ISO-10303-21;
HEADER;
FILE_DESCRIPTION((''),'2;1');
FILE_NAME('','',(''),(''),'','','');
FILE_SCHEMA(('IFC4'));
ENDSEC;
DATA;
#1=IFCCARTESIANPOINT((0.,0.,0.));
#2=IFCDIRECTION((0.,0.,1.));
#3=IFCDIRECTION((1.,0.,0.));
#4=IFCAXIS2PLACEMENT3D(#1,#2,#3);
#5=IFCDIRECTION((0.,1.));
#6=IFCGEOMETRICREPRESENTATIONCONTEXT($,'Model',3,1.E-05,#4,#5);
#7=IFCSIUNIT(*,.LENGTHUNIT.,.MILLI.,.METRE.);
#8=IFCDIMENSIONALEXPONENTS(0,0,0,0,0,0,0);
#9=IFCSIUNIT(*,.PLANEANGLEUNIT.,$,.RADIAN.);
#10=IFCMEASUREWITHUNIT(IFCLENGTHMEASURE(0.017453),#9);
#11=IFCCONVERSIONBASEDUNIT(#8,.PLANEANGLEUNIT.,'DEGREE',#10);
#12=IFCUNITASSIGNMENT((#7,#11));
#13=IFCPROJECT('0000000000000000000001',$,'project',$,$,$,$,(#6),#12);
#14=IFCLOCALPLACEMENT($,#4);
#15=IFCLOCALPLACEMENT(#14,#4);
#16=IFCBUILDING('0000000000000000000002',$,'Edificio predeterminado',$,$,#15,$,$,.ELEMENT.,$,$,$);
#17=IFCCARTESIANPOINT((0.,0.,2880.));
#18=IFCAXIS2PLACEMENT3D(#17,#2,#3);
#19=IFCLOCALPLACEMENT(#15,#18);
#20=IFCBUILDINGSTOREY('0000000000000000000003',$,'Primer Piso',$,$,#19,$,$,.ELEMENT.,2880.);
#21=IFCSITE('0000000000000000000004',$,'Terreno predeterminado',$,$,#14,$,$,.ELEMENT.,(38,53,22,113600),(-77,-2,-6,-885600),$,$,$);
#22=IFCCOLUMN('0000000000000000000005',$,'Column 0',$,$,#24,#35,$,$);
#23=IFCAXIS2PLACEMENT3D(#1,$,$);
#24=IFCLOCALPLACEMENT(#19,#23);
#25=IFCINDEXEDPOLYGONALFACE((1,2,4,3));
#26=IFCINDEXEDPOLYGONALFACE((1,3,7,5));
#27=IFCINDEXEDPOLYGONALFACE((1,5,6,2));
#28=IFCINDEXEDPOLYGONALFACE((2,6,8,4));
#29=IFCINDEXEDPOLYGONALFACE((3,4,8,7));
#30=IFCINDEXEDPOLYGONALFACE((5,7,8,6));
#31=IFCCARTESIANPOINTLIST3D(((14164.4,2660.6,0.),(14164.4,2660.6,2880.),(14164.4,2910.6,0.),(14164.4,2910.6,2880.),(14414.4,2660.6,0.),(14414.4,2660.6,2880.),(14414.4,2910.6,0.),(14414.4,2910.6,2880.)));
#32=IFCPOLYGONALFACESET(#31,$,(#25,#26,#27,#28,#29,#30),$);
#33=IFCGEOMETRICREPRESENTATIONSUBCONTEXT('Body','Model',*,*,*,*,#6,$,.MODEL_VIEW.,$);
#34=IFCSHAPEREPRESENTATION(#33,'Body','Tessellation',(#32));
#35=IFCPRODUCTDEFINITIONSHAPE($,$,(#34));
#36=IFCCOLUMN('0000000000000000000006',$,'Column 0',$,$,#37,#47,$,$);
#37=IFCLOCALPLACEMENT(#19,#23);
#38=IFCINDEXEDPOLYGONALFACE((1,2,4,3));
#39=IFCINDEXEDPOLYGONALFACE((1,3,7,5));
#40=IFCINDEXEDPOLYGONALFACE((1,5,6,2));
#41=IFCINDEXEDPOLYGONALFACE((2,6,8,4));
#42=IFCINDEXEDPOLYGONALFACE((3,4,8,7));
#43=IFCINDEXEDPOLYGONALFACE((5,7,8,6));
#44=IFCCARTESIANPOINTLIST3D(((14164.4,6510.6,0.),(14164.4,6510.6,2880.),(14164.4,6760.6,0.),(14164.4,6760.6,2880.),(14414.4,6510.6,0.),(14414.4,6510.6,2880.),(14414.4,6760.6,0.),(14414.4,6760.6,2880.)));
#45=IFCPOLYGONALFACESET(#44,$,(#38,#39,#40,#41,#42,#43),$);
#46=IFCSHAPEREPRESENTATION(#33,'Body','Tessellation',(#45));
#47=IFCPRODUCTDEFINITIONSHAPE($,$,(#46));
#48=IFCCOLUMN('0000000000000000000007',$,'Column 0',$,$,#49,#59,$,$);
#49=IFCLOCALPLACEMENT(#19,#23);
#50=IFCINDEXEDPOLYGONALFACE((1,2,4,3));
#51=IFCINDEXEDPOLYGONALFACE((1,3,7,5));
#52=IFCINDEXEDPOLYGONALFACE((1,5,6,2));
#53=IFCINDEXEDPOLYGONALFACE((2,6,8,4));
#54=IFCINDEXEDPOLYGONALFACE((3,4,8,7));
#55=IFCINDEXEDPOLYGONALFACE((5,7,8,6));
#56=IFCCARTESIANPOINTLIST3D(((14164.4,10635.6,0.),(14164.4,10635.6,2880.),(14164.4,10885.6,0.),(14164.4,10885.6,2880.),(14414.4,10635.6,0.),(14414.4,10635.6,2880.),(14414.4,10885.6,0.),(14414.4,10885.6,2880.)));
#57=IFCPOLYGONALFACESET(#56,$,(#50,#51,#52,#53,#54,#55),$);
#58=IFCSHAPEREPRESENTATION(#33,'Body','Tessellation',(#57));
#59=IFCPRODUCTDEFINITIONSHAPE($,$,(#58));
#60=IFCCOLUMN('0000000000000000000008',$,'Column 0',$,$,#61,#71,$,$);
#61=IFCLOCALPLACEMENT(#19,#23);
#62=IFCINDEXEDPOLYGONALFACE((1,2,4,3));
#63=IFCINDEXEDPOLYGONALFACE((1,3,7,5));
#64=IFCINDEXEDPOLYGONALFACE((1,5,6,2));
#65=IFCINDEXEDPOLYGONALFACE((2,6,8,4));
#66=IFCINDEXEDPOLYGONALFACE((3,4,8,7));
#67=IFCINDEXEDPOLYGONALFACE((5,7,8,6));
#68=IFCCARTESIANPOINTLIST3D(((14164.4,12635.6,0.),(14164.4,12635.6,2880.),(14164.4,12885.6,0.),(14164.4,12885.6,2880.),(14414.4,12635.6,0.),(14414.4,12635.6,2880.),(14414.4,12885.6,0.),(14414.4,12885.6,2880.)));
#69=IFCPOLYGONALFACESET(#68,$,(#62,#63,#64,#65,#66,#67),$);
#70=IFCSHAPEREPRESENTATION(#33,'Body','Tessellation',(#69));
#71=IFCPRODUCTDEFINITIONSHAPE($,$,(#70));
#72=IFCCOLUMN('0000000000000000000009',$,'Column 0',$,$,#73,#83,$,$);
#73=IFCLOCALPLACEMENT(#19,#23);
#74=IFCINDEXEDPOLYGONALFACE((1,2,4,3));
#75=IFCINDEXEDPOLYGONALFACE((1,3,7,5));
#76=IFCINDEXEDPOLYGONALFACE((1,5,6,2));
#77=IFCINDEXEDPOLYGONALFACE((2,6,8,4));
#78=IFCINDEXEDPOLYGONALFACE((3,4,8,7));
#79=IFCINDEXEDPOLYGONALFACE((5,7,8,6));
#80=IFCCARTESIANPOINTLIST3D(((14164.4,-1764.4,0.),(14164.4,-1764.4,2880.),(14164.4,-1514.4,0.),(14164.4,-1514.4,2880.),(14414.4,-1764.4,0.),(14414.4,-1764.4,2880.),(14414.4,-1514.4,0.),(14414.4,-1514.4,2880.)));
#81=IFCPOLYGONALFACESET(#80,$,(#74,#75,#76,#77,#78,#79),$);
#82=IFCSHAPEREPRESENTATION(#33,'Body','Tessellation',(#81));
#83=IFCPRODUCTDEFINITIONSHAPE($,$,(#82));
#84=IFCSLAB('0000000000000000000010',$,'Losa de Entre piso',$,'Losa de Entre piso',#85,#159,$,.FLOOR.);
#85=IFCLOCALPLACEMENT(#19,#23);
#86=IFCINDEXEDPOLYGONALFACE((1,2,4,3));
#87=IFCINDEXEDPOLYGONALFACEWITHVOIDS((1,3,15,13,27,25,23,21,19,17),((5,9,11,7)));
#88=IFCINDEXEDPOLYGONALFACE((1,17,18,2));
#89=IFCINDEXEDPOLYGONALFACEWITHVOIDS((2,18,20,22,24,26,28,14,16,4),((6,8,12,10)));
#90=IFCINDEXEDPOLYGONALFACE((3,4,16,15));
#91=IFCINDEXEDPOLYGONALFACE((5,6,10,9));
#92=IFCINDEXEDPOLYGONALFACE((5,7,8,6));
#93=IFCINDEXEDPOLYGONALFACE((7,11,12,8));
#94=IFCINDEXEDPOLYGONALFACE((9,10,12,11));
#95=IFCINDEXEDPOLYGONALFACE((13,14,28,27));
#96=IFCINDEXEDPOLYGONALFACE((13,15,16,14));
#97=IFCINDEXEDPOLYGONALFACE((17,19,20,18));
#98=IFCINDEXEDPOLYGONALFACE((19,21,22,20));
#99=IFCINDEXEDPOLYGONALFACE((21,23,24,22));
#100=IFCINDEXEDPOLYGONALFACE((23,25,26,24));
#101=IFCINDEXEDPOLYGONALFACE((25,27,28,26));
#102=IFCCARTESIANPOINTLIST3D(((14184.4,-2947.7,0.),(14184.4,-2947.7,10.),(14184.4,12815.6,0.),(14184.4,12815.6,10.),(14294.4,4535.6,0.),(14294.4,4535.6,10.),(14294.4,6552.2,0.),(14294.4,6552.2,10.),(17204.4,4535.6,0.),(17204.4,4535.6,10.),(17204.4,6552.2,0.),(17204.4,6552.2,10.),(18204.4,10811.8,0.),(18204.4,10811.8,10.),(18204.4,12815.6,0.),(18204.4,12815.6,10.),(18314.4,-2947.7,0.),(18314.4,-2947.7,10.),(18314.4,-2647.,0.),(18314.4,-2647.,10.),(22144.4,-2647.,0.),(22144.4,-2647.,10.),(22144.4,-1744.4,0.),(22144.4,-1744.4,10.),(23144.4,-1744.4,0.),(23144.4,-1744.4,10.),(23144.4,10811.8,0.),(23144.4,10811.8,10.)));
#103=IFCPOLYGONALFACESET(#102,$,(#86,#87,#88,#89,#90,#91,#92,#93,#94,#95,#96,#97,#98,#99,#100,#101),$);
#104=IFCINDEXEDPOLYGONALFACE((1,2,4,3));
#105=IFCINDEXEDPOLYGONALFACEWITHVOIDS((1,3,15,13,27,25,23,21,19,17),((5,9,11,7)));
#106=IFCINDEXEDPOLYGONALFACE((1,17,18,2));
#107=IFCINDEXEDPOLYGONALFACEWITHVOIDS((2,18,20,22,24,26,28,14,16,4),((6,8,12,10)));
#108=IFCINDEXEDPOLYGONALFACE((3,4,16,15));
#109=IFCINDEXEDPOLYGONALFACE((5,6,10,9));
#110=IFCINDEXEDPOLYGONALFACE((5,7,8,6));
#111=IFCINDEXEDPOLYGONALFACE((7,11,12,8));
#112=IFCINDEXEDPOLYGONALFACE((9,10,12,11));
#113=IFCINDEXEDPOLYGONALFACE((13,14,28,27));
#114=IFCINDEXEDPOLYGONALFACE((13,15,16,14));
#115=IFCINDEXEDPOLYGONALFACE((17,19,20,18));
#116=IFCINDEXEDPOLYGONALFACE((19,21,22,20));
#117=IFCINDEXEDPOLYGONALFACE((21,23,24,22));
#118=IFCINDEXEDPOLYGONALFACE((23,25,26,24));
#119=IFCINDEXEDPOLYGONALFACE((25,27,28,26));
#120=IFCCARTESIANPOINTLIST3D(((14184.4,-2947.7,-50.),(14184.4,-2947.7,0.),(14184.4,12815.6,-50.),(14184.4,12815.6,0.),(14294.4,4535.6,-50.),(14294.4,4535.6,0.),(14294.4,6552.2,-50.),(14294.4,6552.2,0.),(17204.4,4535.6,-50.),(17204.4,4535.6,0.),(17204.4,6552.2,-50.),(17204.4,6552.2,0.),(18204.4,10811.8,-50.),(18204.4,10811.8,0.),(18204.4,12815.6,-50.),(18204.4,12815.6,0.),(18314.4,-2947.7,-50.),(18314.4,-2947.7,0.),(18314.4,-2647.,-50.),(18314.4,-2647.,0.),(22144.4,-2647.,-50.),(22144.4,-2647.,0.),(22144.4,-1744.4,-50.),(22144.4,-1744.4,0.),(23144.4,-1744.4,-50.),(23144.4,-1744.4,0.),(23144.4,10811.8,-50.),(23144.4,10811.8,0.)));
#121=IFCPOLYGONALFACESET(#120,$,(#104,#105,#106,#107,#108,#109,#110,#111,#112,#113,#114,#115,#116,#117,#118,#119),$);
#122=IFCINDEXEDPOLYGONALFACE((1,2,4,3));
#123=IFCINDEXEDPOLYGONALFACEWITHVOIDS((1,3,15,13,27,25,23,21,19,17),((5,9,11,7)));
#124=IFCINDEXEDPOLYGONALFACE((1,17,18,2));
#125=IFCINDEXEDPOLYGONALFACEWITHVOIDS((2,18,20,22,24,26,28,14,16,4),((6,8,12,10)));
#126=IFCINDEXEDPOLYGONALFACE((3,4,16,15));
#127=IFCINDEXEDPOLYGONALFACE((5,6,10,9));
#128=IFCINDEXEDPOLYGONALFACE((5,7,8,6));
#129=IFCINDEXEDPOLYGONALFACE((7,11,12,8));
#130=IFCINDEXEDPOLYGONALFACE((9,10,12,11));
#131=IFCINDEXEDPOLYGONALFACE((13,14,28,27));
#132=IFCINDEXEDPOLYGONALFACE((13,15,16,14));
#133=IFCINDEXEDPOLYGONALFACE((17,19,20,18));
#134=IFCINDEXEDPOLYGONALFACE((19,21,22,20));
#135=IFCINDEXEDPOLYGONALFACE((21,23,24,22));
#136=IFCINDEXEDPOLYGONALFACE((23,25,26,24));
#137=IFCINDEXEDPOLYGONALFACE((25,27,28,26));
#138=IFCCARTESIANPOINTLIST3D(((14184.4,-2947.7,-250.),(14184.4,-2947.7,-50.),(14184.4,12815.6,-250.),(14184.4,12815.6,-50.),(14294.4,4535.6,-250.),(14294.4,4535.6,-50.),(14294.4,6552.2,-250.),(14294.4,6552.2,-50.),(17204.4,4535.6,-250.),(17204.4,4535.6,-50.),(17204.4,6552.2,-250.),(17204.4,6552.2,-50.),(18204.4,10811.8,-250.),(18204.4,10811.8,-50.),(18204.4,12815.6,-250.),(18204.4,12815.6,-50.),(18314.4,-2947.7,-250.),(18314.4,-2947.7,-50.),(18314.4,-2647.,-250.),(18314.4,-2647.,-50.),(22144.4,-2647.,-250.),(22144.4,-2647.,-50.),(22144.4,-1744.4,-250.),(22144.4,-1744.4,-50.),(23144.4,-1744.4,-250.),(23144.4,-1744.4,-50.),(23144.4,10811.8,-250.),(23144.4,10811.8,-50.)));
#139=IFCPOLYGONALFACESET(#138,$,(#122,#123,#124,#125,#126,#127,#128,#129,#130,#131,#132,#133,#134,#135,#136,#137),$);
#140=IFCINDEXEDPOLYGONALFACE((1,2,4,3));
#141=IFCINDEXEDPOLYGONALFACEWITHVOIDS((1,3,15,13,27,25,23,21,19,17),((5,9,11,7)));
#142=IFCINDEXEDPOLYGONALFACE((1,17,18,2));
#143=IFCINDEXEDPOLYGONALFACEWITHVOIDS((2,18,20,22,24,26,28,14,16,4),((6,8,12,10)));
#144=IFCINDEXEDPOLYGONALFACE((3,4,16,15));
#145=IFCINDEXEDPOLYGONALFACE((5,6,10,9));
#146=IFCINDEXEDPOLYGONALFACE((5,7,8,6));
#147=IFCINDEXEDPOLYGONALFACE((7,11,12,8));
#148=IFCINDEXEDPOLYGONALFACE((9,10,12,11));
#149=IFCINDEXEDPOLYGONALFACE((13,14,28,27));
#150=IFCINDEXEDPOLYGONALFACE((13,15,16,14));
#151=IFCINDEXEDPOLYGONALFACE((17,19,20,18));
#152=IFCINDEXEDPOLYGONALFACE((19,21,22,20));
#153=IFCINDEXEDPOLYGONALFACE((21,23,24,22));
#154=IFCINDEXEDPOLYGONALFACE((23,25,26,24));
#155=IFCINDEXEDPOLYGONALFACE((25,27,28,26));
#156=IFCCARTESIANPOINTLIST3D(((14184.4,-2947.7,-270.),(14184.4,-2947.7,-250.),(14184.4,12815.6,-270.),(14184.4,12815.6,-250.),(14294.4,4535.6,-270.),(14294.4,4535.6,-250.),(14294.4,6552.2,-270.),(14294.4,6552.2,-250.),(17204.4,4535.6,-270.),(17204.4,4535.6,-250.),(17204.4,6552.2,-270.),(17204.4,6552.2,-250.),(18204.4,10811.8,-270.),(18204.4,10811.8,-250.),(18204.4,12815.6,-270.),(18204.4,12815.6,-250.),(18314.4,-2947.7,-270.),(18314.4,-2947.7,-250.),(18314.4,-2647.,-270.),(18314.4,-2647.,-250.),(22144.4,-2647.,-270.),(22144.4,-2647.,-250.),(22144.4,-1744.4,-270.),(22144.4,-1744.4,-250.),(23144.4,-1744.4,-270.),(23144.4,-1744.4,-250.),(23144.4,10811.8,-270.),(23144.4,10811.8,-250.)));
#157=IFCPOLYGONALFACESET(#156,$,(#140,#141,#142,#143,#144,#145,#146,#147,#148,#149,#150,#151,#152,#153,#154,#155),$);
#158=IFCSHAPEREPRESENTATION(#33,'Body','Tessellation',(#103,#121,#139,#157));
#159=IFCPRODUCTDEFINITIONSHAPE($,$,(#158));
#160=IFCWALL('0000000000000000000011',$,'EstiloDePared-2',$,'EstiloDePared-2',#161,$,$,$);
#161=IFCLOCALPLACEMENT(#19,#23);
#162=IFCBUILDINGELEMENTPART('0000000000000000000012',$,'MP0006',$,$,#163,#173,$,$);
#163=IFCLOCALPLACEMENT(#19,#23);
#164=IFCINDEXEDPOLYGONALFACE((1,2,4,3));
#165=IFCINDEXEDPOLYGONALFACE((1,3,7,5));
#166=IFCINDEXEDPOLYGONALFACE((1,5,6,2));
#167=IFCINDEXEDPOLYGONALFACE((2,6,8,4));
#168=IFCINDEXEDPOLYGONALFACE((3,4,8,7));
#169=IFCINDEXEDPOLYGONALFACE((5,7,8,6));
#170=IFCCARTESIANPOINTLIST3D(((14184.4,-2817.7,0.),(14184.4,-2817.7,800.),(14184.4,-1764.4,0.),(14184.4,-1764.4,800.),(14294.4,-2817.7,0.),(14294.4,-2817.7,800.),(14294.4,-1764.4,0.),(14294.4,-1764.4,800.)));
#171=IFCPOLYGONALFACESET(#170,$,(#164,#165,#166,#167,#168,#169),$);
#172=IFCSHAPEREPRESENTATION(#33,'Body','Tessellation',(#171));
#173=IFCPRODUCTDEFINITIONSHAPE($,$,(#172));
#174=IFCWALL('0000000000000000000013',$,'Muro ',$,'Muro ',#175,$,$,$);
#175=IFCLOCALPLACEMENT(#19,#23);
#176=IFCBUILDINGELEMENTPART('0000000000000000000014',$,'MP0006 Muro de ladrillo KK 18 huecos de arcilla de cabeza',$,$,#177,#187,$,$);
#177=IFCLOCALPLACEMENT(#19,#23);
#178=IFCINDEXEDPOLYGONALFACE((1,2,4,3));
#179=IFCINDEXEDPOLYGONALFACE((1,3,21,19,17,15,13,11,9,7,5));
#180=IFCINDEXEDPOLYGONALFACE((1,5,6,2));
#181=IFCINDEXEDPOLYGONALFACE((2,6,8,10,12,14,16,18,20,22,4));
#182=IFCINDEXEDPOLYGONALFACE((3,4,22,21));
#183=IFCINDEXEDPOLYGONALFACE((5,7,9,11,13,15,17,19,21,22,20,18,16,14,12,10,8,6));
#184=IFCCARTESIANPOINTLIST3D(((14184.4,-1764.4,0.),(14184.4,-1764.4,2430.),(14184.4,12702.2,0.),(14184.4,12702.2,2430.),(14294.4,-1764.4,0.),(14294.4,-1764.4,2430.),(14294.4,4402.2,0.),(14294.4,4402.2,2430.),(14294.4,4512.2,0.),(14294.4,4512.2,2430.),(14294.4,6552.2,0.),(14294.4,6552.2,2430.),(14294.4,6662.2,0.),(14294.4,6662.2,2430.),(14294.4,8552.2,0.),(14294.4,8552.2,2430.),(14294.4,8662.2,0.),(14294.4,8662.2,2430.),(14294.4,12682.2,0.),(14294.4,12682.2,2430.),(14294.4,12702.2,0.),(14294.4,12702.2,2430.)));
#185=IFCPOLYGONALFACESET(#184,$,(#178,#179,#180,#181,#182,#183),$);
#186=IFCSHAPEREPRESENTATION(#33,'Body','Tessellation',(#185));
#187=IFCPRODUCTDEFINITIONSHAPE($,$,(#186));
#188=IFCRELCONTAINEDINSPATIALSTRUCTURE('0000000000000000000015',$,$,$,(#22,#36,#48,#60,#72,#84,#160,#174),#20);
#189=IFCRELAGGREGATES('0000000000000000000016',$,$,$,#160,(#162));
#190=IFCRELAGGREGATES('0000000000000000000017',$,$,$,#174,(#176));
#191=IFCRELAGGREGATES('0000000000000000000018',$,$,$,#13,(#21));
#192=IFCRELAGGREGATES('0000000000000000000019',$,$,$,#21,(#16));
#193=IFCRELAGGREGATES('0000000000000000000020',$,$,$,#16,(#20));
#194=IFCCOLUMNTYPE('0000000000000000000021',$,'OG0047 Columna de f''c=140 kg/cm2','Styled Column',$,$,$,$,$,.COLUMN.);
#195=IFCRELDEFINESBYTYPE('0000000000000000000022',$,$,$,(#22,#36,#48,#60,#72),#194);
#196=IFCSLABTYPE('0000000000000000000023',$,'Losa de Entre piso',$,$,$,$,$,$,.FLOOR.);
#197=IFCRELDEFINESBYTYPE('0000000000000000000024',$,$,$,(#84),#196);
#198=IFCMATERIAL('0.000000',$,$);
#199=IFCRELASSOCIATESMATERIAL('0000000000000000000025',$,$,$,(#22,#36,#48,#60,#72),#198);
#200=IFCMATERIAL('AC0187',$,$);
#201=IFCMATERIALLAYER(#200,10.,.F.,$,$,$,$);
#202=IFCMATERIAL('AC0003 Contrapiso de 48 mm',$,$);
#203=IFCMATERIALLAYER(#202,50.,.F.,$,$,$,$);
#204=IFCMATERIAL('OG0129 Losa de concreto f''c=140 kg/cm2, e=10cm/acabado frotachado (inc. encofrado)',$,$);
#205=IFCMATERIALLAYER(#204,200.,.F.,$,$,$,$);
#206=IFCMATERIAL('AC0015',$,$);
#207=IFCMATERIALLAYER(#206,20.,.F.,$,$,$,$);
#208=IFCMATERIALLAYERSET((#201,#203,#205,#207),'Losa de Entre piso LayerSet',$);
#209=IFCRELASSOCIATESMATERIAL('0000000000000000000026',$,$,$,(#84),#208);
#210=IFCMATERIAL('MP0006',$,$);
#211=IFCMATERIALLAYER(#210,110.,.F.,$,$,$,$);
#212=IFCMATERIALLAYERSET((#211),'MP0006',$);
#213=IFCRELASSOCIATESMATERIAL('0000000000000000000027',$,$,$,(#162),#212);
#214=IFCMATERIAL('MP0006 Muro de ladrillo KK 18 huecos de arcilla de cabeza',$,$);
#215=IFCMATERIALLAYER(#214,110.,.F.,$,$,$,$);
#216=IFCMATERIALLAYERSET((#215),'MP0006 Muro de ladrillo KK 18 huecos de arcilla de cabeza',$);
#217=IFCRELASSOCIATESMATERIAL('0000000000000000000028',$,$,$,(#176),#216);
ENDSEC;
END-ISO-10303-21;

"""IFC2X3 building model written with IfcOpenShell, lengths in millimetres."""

from ifc_helpers import new_model, entity, si_unit, converted_unit, direction, frame, origin_with_axes, place, context, subcontext, project, spatial, polyline, outline, extrude, material, layer, layer_set, layer_usage, type_object, element, aggregate, save


model = new_model("IFC2X3")

# Units and contexts
model_context = context("Model", 3, precision=1e-05, world=origin_with_axes(), true_north=direction((0.0, 1.0)))
body_context = subcontext(model_context, "Body", "Model", "MODEL_VIEW")
ifc_project = project(units=[si_unit("LENGTHUNIT", "METRE", prefix="MILLI"), converted_unit("PLANEANGLEUNIT", "DEGREE", entity("IfcLengthMeasure", 0.017453), si_unit("PLANEANGLEUNIT", "RADIAN"), dimensions=[0, 0, 0, 0, 0, 0, 0])], contexts=[model_context])

# Site, building, storey
site_placement = place(None, origin_with_axes())
site = spatial("IfcSite", under=ifc_project, at=site_placement, Name="Terreno predeterminado", CompositionType="ELEMENT", RefLatitude=(38, 53, 22, 113600), RefLongitude=(-77, -2, -6, -885600))
building_placement = place(site_placement, origin_with_axes())
building = spatial("IfcBuilding", under=site, at=building_placement, Name="Edificio predeterminado", CompositionType="ELEMENT")
storey_placement = place(building_placement, frame((0.0, 0.0, 2880.0), z_axis=(0.0, 0.0, 1.0), x_axis=(1.0, 0.0, 0.0)))
storey = spatial("IfcBuildingStorey", under=building, at=storey_placement, Name="Primer Piso", CompositionType="ELEMENT", Elevation=2880.0)

# Columns
ifc_material_1 = material(Name="0.000000")
column_type = type_object("IfcColumnType", Name="OG0047 Columna de f'c=140 kg/cm2", Description="Styled Column", PredefinedType="COLUMN")
for number, where, z_axis, x_axis, name in (
    (1, (14289.4, 2785.6, 0.0), (0.0, 0.0, 1.0), (1.0, 0.0, 0.0), "Column 0"),
    (2, (14289.4, 6635.6, 0.0), (0.0, 0.0, 1.0), (1.0, 0.0, 0.0), "Column 0"),
    (3, (14289.4, 10760.6, 0.0), (0.0, 0.0, 1.0), (1.0, 0.0, 0.0), "Column 0"),
    (4, (14289.4, 12760.6, 0.0), (0.0, 0.0, 1.0), (1.0, 0.0, 0.0), "Column 0"),
    (5, (14289.4, -1639.4, 0.0), (0.0, 0.0, 1.0), (1.0, 0.0, 0.0), "Column 0"),
):
    element("IfcColumn", number, at=place(storey_placement, frame(where, z_axis=z_axis, x_axis=x_axis)), inside=storey, type_object=column_type, material=ifc_material_1, Name=name, context=body_context, shape_type="SweptSolid", body=[
        extrude(outline(polyline([(-125.0, -125.0), (125.0, -125.0), (125.0, 125.0), (-125.0, 125.0), (-125.0, -125.0)])), origin_with_axes(), (0.0, 0.0, 1.0), 2880.0),
    ])

# Slab
ifc_material_2 = material(Name="AC0187")
ifc_layer_1 = layer(ifc_material_2, 10.0, ventilated=False)
ifc_material_3 = material(Name="AC0003 Contrapiso de 48 mm")
ifc_layer_2 = layer(ifc_material_3, 50.0, ventilated=False)
ifc_material_4 = material(Name="OG0129 Losa de concreto f'c=140 kg/cm2, e=10cm/acabado frotachado (inc. encofrado)")
ifc_layer_3 = layer(ifc_material_4, 200.0, ventilated=False)
ifc_material_5 = material(Name="AC0015")
ifc_layer_4 = layer(ifc_material_5, 20.0, ventilated=False)
ifc_layer_set_1 = layer_set([ifc_layer_1, ifc_layer_2, ifc_layer_3, ifc_layer_4], Name="Losa de Entre piso LayerSet")
ifc_layer_usage_1 = layer_usage(ifc_layer_set_1, "AXIS3", "NEGATIVE", 0.0)
slab_type = type_object("IfcSlabType", Name="Losa de Entre piso", PredefinedType="FLOOR")
slab_placement = place(storey_placement, frame((0.0, 0.0, -2880.0), z_axis=(0.0, 0.0, 1.0), x_axis=(1.0, 0.0, 0.0)))
element("IfcSlab", 6, at=slab_placement, inside=storey, type_object=slab_type, material=ifc_layer_usage_1, Name="Losa de Entre piso", ObjectType="Losa de Entre piso", PredefinedType="FLOOR", context=body_context, shape_type="SweptSolid", body=[
    extrude(outline(polyline([(0.0, 15763.4), (4130.0, 15763.4), (4130.0, 15462.6), (7960.0, 15462.6), (7960.0, 14560.0), (8960.0, 14560.0), (8960.0, 2003.8), (4020.0, 2003.8), (4020.0, 0.0), (0.0, 0.0), (0.0, 15763.4)]), holes=[polyline([(110.0, 6263.4), (3020.0, 6263.4), (3020.0, 8280.0), (110.0, 8280.0), (110.0, 6263.4)])]), frame((14184.4, 12815.6, 2880.0), z_axis=(0.0, 0.0, -1.0), x_axis=(1.0, 0.0, 0.0)), (0.0, 0.0, -1.0), 10.0),
    extrude(outline(polyline([(0.0, 15763.4), (4130.0, 15763.4), (4130.0, 15462.6), (7960.0, 15462.6), (7960.0, 14560.0), (8960.0, 14560.0), (8960.0, 2003.8), (4020.0, 2003.8), (4020.0, 0.0), (0.0, 0.0), (0.0, 15763.4)]), holes=[polyline([(110.0, 6263.4), (3020.0, 6263.4), (3020.0, 8280.0), (110.0, 8280.0), (110.0, 6263.4)])]), frame((14184.4, 12815.6, 2830.0), z_axis=(0.0, 0.0, -1.0), x_axis=(1.0, 0.0, 0.0)), (0.0, 0.0, -1.0), 50.0),
    extrude(outline(polyline([(0.0, 15763.4), (4130.0, 15763.4), (4130.0, 15462.6), (7960.0, 15462.6), (7960.0, 14560.0), (8960.0, 14560.0), (8960.0, 2003.8), (4020.0, 2003.8), (4020.0, 0.0), (0.0, 0.0), (0.0, 15763.4)]), holes=[polyline([(110.0, 6263.4), (3020.0, 6263.4), (3020.0, 8280.0), (110.0, 8280.0), (110.0, 6263.4)])]), frame((14184.4, 12815.6, 2630.0), z_axis=(0.0, 0.0, -1.0), x_axis=(1.0, 0.0, 0.0)), (0.0, 0.0, -1.0), 200.0),
    extrude(outline(polyline([(0.0, 15763.4), (4130.0, 15763.4), (4130.0, 15462.6), (7960.0, 15462.6), (7960.0, 14560.0), (8960.0, 14560.0), (8960.0, 2003.8), (4020.0, 2003.8), (4020.0, 0.0), (0.0, 0.0), (0.0, 15763.4)]), holes=[polyline([(110.0, 6263.4), (3020.0, 6263.4), (3020.0, 8280.0), (110.0, 8280.0), (110.0, 6263.4)])]), frame((14184.4, 12815.6, 2610.0), z_axis=(0.0, 0.0, -1.0), x_axis=(1.0, 0.0, 0.0)), (0.0, 0.0, -1.0), 20.0),
])

# Walls, building element parts
wall_1_placement = place(storey_placement, frame((14239.4, -2817.7, 0.0), z_axis=(0.0, 0.0, 1.0), x_axis=(0.0, 1.0, 0.0)))
wall_1 = element("IfcWall", 7, at=wall_1_placement, inside=storey, Name="EstiloDePared-2", ObjectType="EstiloDePared-2")
ifc_material_6 = material(Name="MP0006")
ifc_layer_5 = layer(ifc_material_6, 110.0, ventilated=False)
ifc_layer_set_2 = layer_set([ifc_layer_5], Name="MP0006")
ifc_layer_usage_2 = layer_usage(ifc_layer_set_2, "AXIS2", "NEGATIVE", -55.0)
building_element_part_1_placement = place(wall_1_placement, origin_with_axes())
building_element_part_1 = element("IfcBuildingElementPart", 8, at=building_element_part_1_placement, material=ifc_layer_usage_2, Name="MP0006", context=body_context, shape_type="SweptSolid", body=[
    extrude(outline(polyline([(1053.4, 55.0), (1053.4, -55.0), (0.0, -55.0), (0.0, 55.0), (1053.4, 55.0)])), origin_with_axes(), (0.0, 0.0, 1.0), 800.0),
])
aggregate(wall_1, [building_element_part_1])
wall_2_placement = place(storey_placement, frame((14239.4, -1764.4, 0.0), z_axis=(0.0, 0.0, 1.0), x_axis=(0.0, 1.0, 0.0)))
wall_2 = element("IfcWall", 9, at=wall_2_placement, inside=storey, Name="Muro ", ObjectType="Muro ")
ifc_material_7 = material(Name="MP0006 Muro de ladrillo KK 18 huecos de arcilla de cabeza")
ifc_layer_6 = layer(ifc_material_7, 110.0, ventilated=False)
ifc_layer_set_3 = layer_set([ifc_layer_6], Name="MP0006 Muro de ladrillo KK 18 huecos de arcilla de cabeza")
ifc_layer_usage_3 = layer_usage(ifc_layer_set_3, "AXIS2", "NEGATIVE", -55.0)
building_element_part_2_placement = place(wall_2_placement, origin_with_axes())
building_element_part_2 = element("IfcBuildingElementPart", 10, at=building_element_part_2_placement, material=ifc_layer_usage_3, Name="MP0006 Muro de ladrillo KK 18 huecos de arcilla de cabeza", context=body_context, shape_type="SweptSolid", body=[
    extrude(outline(polyline([(14466.6, 55.0), (14466.6, -55.0), (14446.6, -55.0), (10426.6, -55.0), (10316.6, -55.0), (8426.6, -55.0), (8316.6, -55.0), (6276.6, -55.0), (6166.6, -55.0), (0.0, -55.0), (0.0, 55.0), (14466.6, 55.0)])), origin_with_axes(), (0.0, 0.0, 1.0), 2430.0),
])
aggregate(wall_2, [building_element_part_2])

save(model, "model.ifc")
